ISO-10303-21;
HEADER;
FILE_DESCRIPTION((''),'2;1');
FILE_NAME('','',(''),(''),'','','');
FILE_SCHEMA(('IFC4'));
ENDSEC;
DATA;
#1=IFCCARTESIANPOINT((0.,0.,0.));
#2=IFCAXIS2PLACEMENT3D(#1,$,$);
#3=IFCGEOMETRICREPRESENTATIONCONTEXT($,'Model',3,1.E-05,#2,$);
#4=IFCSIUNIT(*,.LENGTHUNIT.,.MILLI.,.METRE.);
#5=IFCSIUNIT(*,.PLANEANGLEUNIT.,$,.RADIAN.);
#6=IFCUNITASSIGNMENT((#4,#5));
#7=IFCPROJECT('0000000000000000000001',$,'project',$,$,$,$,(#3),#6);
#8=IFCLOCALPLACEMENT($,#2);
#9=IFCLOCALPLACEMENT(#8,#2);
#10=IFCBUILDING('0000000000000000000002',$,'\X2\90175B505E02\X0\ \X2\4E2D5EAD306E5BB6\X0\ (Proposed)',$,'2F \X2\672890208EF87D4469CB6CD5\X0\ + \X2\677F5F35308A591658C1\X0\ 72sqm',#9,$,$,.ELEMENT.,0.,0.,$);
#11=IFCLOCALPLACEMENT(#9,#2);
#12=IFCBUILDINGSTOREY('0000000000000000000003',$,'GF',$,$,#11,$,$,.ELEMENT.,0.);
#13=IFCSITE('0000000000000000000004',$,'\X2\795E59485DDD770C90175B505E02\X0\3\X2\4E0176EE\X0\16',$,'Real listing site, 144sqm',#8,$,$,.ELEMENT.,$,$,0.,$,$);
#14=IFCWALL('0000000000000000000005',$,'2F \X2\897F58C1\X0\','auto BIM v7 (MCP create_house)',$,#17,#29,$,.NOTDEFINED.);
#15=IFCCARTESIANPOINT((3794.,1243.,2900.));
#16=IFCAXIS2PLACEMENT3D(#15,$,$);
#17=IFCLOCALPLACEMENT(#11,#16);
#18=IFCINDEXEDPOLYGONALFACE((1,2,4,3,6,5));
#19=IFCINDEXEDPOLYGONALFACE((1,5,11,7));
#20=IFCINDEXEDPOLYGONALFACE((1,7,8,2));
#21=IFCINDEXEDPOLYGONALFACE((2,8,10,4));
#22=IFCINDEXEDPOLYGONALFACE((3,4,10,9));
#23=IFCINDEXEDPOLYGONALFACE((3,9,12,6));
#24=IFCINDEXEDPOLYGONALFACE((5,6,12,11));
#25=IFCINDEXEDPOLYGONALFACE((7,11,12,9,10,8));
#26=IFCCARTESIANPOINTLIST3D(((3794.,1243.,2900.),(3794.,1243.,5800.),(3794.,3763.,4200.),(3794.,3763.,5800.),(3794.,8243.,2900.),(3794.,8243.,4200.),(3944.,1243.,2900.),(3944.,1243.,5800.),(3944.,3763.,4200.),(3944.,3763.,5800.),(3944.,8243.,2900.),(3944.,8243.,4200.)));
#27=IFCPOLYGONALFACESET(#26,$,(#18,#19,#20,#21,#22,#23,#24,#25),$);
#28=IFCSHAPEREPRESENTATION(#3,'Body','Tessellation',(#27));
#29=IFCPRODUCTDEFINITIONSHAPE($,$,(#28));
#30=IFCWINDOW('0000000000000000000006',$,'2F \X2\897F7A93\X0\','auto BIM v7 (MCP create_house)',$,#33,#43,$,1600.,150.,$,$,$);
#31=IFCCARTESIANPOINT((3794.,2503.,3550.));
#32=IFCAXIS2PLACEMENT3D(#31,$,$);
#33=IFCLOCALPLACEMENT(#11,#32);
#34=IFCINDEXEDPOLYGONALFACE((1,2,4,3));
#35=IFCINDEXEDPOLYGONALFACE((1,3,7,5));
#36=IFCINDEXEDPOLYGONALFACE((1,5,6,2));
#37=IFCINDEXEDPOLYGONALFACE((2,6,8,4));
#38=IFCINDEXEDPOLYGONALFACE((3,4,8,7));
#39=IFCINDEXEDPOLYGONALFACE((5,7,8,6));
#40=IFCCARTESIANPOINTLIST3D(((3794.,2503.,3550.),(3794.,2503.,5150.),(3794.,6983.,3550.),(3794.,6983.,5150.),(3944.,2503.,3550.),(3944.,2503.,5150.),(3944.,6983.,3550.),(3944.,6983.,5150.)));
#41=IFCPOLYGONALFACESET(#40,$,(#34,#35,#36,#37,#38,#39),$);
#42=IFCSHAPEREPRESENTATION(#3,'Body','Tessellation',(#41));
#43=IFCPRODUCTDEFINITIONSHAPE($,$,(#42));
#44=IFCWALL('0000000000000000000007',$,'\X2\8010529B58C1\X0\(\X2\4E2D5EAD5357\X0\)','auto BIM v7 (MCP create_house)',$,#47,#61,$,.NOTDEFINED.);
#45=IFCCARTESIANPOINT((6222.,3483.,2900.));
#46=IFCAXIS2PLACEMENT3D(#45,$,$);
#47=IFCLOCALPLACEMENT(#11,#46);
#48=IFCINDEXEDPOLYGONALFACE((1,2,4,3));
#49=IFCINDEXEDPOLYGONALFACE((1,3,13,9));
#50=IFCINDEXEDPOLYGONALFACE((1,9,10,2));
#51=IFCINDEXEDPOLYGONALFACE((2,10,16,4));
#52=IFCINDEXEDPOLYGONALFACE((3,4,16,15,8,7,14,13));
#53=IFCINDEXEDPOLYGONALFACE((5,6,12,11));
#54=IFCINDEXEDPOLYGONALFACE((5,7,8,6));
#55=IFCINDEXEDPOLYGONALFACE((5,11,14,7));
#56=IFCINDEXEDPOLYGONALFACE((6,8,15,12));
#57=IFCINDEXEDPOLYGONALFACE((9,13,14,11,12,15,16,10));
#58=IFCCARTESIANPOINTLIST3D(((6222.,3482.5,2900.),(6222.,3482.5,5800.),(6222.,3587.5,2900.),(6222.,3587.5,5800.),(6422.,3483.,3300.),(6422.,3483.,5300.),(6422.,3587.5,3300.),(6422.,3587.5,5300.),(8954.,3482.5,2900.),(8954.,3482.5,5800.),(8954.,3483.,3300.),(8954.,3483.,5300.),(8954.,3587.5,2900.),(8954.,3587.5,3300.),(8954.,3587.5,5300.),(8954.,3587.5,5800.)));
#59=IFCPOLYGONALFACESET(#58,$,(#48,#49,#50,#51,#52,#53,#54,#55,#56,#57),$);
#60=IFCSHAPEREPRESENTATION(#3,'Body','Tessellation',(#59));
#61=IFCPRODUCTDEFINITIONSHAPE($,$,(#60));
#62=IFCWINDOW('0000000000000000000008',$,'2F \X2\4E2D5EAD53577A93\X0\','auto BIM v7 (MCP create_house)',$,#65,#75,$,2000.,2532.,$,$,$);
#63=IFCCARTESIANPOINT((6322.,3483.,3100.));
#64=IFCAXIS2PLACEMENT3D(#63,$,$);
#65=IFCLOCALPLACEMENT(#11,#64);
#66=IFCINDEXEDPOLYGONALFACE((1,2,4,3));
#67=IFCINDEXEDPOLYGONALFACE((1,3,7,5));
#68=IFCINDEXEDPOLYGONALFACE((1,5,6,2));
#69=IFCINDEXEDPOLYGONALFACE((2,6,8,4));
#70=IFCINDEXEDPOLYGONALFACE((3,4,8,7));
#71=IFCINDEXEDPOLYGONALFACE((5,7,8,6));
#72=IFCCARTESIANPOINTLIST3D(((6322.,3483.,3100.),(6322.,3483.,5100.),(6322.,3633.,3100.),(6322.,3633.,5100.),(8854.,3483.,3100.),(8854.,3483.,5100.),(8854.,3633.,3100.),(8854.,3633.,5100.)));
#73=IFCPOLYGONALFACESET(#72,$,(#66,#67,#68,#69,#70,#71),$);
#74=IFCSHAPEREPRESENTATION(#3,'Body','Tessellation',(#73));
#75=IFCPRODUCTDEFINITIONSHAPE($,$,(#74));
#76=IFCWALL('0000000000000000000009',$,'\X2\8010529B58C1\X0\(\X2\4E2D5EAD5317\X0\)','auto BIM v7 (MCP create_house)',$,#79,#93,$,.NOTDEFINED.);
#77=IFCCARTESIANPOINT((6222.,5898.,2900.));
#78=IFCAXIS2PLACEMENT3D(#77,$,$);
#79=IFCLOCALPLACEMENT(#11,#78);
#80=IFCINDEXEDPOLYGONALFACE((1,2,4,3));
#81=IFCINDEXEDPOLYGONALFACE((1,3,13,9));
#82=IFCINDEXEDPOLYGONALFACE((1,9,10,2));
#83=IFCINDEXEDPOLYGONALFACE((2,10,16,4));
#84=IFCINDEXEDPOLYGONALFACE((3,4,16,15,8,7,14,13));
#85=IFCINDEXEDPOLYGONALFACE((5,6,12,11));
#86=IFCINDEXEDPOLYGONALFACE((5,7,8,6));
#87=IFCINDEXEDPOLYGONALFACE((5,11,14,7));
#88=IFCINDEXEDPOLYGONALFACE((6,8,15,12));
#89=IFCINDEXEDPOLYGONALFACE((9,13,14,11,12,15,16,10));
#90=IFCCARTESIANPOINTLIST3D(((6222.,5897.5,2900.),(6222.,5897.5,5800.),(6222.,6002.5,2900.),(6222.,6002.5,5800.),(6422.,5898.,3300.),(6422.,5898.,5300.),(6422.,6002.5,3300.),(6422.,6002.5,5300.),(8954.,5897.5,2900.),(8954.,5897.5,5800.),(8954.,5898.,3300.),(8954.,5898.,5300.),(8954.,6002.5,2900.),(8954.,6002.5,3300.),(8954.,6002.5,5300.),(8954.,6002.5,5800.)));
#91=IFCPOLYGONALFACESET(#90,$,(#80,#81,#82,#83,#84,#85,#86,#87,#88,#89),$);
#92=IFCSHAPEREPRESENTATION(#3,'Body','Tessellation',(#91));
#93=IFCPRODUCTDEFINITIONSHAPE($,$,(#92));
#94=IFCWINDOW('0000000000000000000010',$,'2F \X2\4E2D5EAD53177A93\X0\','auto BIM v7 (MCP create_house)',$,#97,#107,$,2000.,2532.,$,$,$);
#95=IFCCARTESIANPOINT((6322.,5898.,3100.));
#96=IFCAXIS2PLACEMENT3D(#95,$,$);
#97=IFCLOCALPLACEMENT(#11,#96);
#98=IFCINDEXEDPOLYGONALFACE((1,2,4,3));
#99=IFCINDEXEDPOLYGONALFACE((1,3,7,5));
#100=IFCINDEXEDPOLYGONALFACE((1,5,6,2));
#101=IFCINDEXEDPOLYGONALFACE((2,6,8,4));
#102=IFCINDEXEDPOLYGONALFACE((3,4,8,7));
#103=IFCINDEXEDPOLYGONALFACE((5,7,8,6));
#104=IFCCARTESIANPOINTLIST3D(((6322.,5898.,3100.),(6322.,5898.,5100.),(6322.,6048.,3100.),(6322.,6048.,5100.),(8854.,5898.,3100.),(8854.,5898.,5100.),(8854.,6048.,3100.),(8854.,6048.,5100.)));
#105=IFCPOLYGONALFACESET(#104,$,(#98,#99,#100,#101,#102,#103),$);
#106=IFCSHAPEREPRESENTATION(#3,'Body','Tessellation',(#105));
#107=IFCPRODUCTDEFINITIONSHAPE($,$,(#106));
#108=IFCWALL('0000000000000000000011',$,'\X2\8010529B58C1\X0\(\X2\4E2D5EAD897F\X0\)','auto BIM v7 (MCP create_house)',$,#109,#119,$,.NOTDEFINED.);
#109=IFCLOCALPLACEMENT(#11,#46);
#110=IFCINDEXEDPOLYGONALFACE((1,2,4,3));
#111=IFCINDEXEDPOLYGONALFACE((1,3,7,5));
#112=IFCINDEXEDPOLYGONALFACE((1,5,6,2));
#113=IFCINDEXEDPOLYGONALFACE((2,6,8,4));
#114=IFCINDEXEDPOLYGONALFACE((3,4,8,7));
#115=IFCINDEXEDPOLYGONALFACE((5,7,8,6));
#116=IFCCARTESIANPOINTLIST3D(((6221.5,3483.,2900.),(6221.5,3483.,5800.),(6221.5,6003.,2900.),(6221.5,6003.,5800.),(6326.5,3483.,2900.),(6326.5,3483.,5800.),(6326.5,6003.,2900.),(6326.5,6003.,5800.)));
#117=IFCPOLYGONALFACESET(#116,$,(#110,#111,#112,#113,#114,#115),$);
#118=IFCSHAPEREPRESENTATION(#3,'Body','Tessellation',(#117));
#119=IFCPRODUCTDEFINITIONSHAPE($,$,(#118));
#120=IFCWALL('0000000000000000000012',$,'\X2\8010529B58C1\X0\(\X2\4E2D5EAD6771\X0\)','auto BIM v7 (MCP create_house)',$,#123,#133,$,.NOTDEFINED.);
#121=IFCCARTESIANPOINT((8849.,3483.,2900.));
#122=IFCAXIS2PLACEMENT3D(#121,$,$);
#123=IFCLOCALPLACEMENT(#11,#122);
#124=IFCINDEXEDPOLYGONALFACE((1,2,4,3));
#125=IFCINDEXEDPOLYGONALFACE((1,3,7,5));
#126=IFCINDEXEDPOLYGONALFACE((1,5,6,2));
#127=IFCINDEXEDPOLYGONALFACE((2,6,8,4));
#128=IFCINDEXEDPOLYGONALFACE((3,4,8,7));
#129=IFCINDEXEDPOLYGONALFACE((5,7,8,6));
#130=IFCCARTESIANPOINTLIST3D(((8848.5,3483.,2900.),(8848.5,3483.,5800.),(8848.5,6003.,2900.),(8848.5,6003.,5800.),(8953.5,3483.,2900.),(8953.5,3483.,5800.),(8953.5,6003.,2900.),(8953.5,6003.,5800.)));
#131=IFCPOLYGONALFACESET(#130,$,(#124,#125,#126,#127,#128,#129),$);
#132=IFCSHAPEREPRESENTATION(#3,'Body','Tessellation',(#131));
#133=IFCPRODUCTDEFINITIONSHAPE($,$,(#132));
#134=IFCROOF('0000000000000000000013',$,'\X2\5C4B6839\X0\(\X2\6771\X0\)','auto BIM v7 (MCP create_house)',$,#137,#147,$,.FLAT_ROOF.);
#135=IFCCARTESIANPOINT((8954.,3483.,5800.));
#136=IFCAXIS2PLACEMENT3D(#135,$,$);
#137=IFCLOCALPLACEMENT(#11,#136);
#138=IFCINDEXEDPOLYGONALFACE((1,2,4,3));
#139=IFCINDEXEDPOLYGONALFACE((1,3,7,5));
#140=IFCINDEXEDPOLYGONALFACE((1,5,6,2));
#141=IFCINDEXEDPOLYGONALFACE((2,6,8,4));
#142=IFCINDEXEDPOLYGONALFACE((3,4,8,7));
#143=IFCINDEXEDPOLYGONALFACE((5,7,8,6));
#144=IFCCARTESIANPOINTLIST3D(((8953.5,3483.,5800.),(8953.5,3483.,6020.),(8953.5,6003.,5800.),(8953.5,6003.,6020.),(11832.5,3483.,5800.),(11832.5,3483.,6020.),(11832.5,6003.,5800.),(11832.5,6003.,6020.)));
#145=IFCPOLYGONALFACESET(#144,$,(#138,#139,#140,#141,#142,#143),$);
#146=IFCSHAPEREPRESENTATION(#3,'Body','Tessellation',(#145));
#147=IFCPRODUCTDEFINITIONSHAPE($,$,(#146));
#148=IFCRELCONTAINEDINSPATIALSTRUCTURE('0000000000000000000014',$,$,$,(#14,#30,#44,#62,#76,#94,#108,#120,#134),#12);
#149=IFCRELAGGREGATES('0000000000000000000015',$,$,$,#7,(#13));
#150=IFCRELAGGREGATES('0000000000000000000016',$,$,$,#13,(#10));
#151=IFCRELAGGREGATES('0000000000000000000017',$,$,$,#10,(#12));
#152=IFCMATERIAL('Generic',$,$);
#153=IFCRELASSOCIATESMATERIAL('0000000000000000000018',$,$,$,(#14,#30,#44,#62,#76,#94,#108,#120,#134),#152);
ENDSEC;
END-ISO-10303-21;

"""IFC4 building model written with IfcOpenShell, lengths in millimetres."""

from ifc_helpers import new_model, si_unit, frame, frame_2d, origin, place, context, project, spatial, rectangle, extrude, material, element, fill, save


model = new_model("IFC4")

# Units and contexts
model_context = context("Model", 3, precision=1e-05, world=origin())
ifc_project = project(units=[si_unit("LENGTHUNIT", "METRE", prefix="MILLI"), si_unit("PLANEANGLEUNIT", "RADIAN")], contexts=[model_context])

# Site, building, storey
site_placement = place(None, origin())
site = spatial("IfcSite", under=ifc_project, at=site_placement, Name="神奈川県逗子市3丁目16", ObjectType="Real listing site, 144sqm", CompositionType="ELEMENT", RefElevation=0.0)
building_placement = place(site_placement, origin())
building = spatial("IfcBuilding", under=site, at=building_placement, Name="逗子市 中庭の家 (Proposed)", ObjectType="2F 木造軸組構法 + 板張り外壁 72sqm", CompositionType="ELEMENT", ElevationOfRefHeight=0.0, ElevationOfTerrain=0.0)
storey_placement = place(building_placement, origin())
storey = spatial("IfcBuildingStorey", under=building, at=storey_placement, Name="GF", CompositionType="ELEMENT", Elevation=0.0)

# Shared definitions
ifc_material = material(Name="Generic")

# Walls, openings, windows
wall_1_placement = place(storey_placement, frame((3794.0, 1243.0, 2900.0)))
wall_1 = element("IfcWall", 1, at=wall_1_placement, inside=storey, material=ifc_material, Name="2F 西壁", Description="auto BIM v7 (MCP create_house)", PredefinedType="NOTDEFINED", context=model_context, shape_type="SweptSolid", body=[
    extrude(rectangle(XDim=150.0, YDim=7000.0, at=frame_2d((75.0, 3500.0))), frame((3794.0, 1243.0, 2900.0)), (0.0, 0.0, 1.0), 2900.0),
])
opening_1_placement = place(storey_placement, frame((3794.0, 2503.0, 3550.0)))
opening_1 = element("IfcOpeningElement", 2, at=opening_1_placement, cuts=wall_1, PredefinedType="NOTDEFINED", context=model_context, shape_type="SweptSolid", body=[
    extrude(rectangle(XDim=150.0, YDim=4480.0, at=frame_2d((75.0, 2240.0))), frame((3794.0, 2503.0, 3550.0)), (0.0, 0.0, 1.0), 1600.0),
])
window_1_placement = place(storey_placement, frame((3794.0, 2503.0, 3550.0)))
window_1 = element("IfcWindow", 3, at=window_1_placement, inside=storey, material=ifc_material, Name="2F 西窓", Description="auto BIM v7 (MCP create_house)", OverallHeight=1600.0, OverallWidth=150.0, context=model_context, shape_type="SweptSolid", body=[
    extrude(rectangle(XDim=150.0, YDim=4480.0, at=frame_2d((75.0, 2240.0))), frame((3794.0, 2503.0, 3550.0)), (0.0, 0.0, 1.0), 1600.0),
])
fill(opening_1, window_1)
wall_2_placement = place(storey_placement, frame((6222.0, 3483.0, 2900.0)))
wall_2 = element("IfcWall", 4, at=wall_2_placement, inside=storey, material=ifc_material, Name="耐力壁(中庭南)", Description="auto BIM v7 (MCP create_house)", PredefinedType="NOTDEFINED", context=model_context, shape_type="SweptSolid", body=[
    extrude(rectangle(XDim=2732.0, YDim=105.0, at=frame_2d((1366.0, 52.0))), frame((6222.0, 3483.0, 2900.0)), (0.0, 0.0, 1.0), 2900.0),
])
opening_2_placement = place(storey_placement, frame((6322.0, 3483.0, 3100.0)))
opening_2 = element("IfcOpeningElement", 5, at=opening_2_placement, cuts=wall_2, PredefinedType="NOTDEFINED", context=model_context, shape_type="SweptSolid", body=[
    extrude(rectangle(XDim=2532.0, YDim=150.0, at=frame_2d((1266.0, 75.0))), frame((6322.0, 3483.0, 3100.0)), (0.0, 0.0, 1.0), 2000.0),
])
window_2_placement = place(storey_placement, frame((6322.0, 3483.0, 3100.0)))
window_2 = element("IfcWindow", 6, at=window_2_placement, inside=storey, material=ifc_material, Name="2F 中庭南窓", Description="auto BIM v7 (MCP create_house)", OverallHeight=2000.0, OverallWidth=2532.0, context=model_context, shape_type="SweptSolid", body=[
    extrude(rectangle(XDim=2532.0, YDim=150.0, at=frame_2d((1266.0, 75.0))), frame((6322.0, 3483.0, 3100.0)), (0.0, 0.0, 1.0), 2000.0),
])
fill(opening_2, window_2)
wall_3_placement = place(storey_placement, frame((6222.0, 5898.0, 2900.0)))
wall_3 = element("IfcWall", 7, at=wall_3_placement, inside=storey, material=ifc_material, Name="耐力壁(中庭北)", Description="auto BIM v7 (MCP create_house)", PredefinedType="NOTDEFINED", context=model_context, shape_type="SweptSolid", body=[
    extrude(rectangle(XDim=2732.0, YDim=105.0, at=frame_2d((1366.0, 52.0))), frame((6222.0, 5898.0, 2900.0)), (0.0, 0.0, 1.0), 2900.0),
])
opening_3_placement = place(storey_placement, frame((6322.0, 5898.0, 3100.0)))
opening_3 = element("IfcOpeningElement", 8, at=opening_3_placement, cuts=wall_3, PredefinedType="NOTDEFINED", context=model_context, shape_type="SweptSolid", body=[
    extrude(rectangle(XDim=2532.0, YDim=150.0, at=frame_2d((1266.0, 75.0))), frame((6322.0, 5898.0, 3100.0)), (0.0, 0.0, 1.0), 2000.0),
])
window_3_placement = place(storey_placement, frame((6322.0, 5898.0, 3100.0)))
window_3 = element("IfcWindow", 9, at=window_3_placement, inside=storey, material=ifc_material, Name="2F 中庭北窓", Description="auto BIM v7 (MCP create_house)", OverallHeight=2000.0, OverallWidth=2532.0, context=model_context, shape_type="SweptSolid", body=[
    extrude(rectangle(XDim=2532.0, YDim=150.0, at=frame_2d((1266.0, 75.0))), frame((6322.0, 5898.0, 3100.0)), (0.0, 0.0, 1.0), 2000.0),
])
fill(opening_3, window_3)

# Walls
wall_4_placement = place(storey_placement, frame((6222.0, 3483.0, 2900.0)))
element("IfcWall", 10, at=wall_4_placement, inside=storey, material=ifc_material, Name="耐力壁(中庭西)", Description="auto BIM v7 (MCP create_house)", PredefinedType="NOTDEFINED", context=model_context, shape_type="SweptSolid", body=[
    extrude(rectangle(XDim=105.0, YDim=2520.0, at=frame_2d((52.0, 1260.0))), frame((6222.0, 3483.0, 2900.0)), (0.0, 0.0, 1.0), 2900.0),
])
wall_5_placement = place(storey_placement, frame((8849.0, 3483.0, 2900.0)))
element("IfcWall", 11, at=wall_5_placement, inside=storey, material=ifc_material, Name="耐力壁(中庭東)", Description="auto BIM v7 (MCP create_house)", PredefinedType="NOTDEFINED", context=model_context, shape_type="SweptSolid", body=[
    extrude(rectangle(XDim=105.0, YDim=2520.0, at=frame_2d((52.0, 1260.0))), frame((8849.0, 3483.0, 2900.0)), (0.0, 0.0, 1.0), 2900.0),
])

# Roof
for number, where, name in (
    (12, (8954.0, 3483.0, 5800.0), "屋根(東)"),
):
    element("IfcRoof", number, at=place(storey_placement, frame(where)), inside=storey, material=ifc_material, Name=name, Description="auto BIM v7 (MCP create_house)", PredefinedType="FLAT_ROOF", context=model_context, shape_type="SweptSolid", body=[
        extrude(rectangle(XDim=2879.0, YDim=2520.0, at=frame_2d((1439.0, 1260.0))), frame((8954.0, 3483.0, 5800.0)), (0.0, 0.0, 1.0), 220.0),
    ])

save(model, "model.ifc")
